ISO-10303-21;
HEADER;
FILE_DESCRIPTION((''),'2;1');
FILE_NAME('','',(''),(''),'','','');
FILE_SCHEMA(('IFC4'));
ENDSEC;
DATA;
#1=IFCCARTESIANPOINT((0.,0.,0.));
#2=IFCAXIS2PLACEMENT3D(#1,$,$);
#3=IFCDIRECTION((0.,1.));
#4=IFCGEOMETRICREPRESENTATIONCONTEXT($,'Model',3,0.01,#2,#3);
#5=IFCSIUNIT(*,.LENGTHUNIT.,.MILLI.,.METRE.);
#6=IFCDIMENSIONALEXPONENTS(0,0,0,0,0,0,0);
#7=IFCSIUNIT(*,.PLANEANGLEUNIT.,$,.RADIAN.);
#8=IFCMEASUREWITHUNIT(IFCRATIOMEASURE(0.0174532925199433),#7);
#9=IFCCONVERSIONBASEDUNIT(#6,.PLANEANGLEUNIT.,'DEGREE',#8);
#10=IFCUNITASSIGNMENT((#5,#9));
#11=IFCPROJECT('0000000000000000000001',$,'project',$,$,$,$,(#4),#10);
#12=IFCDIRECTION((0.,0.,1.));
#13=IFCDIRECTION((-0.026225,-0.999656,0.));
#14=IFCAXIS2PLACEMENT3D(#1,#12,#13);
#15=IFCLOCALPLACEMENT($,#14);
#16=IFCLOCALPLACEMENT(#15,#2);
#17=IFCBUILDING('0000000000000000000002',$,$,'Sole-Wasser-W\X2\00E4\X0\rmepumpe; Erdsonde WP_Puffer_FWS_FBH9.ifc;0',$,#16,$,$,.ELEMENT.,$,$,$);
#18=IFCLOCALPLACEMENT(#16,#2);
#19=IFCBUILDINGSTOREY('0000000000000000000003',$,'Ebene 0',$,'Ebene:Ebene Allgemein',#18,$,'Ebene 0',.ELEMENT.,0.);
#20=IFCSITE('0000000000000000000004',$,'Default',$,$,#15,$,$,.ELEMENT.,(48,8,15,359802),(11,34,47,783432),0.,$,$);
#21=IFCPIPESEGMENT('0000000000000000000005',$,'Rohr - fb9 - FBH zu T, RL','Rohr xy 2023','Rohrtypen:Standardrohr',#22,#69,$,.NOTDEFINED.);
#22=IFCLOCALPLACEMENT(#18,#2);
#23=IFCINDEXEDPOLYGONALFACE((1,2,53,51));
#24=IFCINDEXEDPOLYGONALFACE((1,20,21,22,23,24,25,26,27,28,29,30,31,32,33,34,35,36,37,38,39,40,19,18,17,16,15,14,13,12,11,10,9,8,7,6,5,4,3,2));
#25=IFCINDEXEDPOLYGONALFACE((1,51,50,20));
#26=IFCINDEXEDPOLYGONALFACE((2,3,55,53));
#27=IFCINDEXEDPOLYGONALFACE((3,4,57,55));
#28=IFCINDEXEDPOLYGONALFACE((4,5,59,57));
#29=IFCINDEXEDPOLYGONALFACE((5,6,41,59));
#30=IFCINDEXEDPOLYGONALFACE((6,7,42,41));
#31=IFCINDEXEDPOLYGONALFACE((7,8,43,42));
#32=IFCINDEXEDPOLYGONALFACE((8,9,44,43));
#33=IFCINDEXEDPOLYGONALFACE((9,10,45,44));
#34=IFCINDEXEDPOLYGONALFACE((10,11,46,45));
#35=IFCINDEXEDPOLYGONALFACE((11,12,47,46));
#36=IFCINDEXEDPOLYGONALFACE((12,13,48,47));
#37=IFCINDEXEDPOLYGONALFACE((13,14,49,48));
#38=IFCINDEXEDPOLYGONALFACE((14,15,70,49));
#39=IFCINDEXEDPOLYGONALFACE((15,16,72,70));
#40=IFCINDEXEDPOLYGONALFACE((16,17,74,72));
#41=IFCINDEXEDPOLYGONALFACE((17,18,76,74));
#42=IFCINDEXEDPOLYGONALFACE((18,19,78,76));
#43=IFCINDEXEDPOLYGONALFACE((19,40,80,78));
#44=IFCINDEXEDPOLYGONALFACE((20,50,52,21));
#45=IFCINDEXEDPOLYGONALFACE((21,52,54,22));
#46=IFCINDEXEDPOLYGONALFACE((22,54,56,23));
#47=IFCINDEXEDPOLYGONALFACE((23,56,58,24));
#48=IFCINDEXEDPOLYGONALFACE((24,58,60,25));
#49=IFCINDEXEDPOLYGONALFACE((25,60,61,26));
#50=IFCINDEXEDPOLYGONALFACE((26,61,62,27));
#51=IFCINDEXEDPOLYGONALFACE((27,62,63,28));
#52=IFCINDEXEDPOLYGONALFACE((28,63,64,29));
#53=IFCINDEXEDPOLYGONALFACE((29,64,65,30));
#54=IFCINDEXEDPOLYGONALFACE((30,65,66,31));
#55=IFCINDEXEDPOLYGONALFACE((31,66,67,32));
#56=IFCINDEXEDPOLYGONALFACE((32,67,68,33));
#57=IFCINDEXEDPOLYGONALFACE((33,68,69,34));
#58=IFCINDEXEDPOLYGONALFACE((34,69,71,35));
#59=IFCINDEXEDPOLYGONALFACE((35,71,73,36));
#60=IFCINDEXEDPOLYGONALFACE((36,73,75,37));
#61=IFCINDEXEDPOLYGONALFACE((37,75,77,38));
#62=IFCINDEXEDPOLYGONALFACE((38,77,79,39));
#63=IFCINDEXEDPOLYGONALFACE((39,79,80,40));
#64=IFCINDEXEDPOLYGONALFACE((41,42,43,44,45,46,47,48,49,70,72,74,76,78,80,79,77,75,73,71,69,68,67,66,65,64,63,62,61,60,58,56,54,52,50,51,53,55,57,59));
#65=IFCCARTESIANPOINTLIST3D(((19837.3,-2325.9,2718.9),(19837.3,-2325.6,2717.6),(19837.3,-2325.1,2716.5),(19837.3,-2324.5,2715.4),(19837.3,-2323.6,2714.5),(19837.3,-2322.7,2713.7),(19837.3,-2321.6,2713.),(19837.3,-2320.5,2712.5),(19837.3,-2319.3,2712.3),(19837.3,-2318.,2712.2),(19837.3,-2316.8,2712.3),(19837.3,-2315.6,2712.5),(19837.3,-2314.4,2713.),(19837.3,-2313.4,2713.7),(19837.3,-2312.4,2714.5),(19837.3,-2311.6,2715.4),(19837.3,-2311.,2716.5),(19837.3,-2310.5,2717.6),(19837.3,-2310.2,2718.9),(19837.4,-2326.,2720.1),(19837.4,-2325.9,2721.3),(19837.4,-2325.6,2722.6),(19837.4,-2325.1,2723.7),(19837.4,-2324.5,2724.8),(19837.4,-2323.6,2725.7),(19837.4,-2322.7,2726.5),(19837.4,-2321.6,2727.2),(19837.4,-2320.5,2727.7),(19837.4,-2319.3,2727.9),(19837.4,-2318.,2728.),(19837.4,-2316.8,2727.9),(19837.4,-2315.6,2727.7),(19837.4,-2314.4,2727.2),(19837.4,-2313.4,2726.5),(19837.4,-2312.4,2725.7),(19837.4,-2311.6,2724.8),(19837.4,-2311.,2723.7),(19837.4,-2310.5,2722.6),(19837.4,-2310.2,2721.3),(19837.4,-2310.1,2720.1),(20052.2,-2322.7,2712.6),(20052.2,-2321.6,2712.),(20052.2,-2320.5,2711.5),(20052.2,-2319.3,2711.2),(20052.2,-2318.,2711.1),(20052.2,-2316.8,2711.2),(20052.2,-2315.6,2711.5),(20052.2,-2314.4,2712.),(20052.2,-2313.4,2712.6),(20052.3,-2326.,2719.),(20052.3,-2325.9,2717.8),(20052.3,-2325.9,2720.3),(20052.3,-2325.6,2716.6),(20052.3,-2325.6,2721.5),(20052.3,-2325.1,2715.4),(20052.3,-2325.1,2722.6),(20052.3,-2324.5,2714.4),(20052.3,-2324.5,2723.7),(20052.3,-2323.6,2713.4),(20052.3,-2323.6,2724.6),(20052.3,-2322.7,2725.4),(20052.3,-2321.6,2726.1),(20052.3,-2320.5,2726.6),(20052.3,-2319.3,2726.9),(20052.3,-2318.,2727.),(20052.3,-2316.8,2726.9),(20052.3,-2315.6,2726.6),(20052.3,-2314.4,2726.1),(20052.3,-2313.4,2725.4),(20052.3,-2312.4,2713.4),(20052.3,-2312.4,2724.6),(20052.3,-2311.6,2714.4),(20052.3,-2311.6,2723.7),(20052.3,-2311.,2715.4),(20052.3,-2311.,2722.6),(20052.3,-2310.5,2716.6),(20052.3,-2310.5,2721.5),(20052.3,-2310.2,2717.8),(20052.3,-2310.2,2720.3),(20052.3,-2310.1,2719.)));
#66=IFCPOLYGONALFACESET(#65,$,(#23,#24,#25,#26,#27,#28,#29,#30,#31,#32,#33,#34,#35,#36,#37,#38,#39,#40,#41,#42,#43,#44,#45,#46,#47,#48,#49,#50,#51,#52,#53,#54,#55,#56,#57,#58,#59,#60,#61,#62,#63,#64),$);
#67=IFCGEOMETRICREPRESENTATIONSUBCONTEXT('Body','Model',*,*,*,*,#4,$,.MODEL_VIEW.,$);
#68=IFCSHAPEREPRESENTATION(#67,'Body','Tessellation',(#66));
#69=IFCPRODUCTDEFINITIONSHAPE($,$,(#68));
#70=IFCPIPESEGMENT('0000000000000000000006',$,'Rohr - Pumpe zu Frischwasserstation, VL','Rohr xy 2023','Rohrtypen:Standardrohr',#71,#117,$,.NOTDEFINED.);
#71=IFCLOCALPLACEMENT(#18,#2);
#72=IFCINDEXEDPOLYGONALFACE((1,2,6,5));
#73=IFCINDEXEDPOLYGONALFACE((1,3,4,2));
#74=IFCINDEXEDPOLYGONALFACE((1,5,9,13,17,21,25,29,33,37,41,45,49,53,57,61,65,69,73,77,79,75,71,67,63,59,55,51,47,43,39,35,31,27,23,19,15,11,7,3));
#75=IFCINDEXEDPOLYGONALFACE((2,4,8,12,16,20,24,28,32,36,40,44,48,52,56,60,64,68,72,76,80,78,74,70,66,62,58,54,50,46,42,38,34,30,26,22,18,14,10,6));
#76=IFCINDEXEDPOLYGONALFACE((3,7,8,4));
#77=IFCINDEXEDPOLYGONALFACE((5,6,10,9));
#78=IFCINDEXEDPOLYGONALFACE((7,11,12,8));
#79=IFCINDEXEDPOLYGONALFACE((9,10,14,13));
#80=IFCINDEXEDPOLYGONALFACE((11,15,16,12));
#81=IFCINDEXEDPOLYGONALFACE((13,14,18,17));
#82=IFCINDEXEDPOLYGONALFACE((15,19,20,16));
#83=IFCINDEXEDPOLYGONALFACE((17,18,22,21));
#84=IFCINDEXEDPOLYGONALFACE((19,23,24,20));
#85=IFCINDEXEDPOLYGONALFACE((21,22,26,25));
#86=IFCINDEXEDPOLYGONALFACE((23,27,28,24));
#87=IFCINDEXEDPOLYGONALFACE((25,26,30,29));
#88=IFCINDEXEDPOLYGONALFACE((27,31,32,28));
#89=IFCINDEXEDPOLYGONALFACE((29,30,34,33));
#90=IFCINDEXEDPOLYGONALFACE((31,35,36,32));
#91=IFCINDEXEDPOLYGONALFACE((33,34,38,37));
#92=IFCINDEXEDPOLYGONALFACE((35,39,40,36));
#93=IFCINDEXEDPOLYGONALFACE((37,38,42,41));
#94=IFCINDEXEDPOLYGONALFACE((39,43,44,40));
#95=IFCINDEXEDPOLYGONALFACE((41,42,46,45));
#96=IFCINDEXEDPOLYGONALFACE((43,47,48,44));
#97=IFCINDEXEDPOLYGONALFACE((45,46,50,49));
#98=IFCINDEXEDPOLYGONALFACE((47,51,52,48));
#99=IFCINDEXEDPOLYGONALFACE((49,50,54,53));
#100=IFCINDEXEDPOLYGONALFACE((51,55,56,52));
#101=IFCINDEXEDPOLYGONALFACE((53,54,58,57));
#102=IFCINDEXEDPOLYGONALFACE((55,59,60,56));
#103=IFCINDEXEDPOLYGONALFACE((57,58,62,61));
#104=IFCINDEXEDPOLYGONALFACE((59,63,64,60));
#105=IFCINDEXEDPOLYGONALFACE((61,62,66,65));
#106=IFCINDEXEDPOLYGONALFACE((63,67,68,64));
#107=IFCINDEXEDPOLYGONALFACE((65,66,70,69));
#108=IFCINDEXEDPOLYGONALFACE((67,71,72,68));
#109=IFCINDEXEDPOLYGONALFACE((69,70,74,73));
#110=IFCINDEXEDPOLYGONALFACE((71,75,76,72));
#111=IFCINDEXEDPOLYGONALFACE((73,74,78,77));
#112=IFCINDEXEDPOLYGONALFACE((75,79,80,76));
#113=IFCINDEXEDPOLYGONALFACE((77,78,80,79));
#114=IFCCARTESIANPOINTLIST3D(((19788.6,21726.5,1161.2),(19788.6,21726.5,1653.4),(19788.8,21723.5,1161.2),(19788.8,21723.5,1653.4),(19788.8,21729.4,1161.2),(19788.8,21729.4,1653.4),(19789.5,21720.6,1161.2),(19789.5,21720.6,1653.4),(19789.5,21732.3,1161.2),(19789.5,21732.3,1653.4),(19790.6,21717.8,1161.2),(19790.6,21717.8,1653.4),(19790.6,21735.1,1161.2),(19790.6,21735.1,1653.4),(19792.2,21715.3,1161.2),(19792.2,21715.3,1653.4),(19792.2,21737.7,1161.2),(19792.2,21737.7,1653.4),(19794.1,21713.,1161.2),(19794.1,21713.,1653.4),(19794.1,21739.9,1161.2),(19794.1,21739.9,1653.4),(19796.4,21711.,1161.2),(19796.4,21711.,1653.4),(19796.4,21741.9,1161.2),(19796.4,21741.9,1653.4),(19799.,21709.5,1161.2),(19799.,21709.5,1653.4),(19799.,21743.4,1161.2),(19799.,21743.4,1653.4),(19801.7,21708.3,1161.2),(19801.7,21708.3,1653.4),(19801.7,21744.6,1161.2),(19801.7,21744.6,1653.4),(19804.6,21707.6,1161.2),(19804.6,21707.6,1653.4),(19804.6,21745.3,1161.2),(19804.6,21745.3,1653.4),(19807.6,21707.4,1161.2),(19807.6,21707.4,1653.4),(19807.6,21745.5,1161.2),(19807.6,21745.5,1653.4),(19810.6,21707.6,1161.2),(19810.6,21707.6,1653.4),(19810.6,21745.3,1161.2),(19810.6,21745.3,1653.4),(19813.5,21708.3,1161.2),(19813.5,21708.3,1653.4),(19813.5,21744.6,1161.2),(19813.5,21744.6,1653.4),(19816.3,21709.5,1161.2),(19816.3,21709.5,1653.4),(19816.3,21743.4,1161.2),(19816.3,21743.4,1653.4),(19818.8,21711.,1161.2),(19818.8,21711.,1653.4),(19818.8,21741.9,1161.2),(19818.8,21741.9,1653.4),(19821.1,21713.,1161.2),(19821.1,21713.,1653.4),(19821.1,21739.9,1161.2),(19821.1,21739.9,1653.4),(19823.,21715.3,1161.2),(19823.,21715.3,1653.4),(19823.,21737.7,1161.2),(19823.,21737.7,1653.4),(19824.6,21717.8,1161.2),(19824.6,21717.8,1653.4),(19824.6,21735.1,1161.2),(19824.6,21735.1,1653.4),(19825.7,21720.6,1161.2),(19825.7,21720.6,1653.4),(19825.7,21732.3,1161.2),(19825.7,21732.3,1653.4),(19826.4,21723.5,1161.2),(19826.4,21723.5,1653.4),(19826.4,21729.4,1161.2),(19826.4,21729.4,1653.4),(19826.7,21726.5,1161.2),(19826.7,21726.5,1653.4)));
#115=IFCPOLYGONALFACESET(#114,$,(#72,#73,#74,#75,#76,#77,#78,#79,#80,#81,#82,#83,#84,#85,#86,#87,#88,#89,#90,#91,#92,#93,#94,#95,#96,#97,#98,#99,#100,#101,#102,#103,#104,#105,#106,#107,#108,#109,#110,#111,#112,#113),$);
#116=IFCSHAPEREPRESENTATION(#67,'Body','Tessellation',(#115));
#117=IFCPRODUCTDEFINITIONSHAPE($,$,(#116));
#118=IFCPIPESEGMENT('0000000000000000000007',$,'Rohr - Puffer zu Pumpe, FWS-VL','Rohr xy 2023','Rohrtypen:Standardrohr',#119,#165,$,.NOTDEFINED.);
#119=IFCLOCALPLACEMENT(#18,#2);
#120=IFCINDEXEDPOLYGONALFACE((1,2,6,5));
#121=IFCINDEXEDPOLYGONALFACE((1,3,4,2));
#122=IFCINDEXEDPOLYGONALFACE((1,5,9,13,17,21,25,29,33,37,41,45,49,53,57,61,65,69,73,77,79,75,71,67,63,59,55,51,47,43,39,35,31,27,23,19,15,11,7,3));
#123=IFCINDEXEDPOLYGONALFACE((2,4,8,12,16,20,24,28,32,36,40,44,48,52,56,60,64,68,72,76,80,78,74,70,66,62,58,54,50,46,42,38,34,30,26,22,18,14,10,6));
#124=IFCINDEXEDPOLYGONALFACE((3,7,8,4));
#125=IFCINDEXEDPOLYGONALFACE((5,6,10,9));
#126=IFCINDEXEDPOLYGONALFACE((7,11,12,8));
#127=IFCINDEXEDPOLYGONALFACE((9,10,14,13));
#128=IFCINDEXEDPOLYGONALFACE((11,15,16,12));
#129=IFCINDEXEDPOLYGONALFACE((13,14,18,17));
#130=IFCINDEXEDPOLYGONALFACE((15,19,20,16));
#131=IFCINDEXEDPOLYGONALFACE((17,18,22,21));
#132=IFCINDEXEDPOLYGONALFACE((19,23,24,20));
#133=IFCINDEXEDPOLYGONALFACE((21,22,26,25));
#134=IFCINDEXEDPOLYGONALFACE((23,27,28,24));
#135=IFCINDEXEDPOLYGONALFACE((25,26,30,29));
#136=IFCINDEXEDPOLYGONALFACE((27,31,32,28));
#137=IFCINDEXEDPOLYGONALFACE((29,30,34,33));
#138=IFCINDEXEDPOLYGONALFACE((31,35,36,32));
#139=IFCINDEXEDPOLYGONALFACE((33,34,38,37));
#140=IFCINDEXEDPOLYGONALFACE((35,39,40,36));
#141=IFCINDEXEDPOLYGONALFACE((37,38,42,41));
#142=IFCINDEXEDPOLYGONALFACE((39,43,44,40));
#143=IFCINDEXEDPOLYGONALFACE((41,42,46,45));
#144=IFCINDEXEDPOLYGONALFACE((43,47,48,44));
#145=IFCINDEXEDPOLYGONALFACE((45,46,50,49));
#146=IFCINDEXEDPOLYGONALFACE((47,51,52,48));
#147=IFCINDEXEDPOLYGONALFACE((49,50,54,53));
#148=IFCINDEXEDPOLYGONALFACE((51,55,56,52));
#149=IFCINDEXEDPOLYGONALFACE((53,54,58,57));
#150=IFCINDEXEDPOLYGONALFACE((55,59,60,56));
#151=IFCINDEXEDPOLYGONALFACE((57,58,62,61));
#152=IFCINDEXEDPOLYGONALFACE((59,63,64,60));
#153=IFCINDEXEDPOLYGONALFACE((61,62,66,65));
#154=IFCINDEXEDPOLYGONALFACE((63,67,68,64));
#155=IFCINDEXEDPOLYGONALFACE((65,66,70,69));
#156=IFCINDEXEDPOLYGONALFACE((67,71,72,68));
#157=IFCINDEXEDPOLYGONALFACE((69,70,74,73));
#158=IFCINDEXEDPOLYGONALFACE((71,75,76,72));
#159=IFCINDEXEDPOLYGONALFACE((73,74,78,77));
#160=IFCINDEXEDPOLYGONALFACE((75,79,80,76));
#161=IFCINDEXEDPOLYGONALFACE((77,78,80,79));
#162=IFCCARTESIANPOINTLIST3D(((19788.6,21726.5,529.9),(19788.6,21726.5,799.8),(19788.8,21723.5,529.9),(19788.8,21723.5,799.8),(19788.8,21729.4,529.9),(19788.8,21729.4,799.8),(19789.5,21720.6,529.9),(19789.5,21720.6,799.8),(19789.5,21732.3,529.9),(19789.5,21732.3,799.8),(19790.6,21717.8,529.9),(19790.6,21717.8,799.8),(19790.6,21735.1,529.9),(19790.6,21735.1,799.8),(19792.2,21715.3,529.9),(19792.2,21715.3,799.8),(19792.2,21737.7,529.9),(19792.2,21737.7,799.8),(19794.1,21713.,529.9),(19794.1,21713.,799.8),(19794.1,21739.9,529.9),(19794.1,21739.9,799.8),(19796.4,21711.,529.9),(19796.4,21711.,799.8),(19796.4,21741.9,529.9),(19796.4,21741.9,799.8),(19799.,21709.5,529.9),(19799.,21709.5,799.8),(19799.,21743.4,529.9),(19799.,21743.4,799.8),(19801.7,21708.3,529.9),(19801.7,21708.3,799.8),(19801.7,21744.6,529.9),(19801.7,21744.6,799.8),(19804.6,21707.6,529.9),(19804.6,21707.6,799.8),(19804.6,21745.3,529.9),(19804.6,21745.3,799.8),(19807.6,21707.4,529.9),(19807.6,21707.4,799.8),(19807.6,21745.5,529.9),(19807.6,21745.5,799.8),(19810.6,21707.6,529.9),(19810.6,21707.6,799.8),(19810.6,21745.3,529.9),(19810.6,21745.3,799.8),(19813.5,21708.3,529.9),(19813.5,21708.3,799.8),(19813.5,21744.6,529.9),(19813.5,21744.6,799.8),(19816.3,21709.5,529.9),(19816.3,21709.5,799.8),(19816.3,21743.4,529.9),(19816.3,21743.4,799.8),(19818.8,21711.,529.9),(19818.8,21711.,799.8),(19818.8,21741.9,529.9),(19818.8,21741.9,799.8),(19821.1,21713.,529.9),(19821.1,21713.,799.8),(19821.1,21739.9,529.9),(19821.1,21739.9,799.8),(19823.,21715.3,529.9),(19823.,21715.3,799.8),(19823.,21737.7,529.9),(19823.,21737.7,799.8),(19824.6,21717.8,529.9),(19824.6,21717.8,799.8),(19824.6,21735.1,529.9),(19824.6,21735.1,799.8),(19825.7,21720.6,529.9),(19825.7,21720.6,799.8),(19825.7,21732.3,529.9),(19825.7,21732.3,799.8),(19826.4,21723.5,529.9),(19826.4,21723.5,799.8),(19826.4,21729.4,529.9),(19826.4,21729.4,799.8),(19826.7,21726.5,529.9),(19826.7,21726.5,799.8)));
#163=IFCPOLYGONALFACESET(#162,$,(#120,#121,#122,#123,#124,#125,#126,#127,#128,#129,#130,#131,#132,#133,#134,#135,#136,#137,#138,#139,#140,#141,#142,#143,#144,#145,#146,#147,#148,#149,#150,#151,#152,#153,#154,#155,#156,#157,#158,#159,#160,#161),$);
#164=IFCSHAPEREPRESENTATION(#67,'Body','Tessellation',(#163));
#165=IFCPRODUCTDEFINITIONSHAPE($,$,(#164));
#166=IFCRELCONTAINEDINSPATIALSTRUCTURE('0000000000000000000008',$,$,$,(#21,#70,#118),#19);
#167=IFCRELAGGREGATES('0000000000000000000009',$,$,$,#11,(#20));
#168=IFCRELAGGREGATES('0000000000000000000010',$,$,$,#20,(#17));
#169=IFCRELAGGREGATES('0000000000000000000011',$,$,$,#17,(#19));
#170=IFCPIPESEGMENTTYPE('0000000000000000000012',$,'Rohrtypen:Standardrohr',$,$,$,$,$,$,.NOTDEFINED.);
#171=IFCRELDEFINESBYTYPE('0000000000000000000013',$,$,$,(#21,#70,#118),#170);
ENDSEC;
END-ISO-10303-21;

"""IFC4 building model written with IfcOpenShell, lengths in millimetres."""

from ifc_helpers import new_model, entity, si_unit, converted_unit, direction, frame, origin, place, context, subcontext, project, spatial, indexed_curve, outline, extrude, type_object, element, save


model = new_model("IFC4")

# Units and contexts
model_context = context("Model", 3, precision=0.01, world=origin(), true_north=direction((0.0, 1.0)))
body_context = subcontext(model_context, "Body", "Model", "MODEL_VIEW")
ifc_project = project(units=[si_unit("LENGTHUNIT", "METRE", prefix="MILLI"), converted_unit("PLANEANGLEUNIT", "DEGREE", entity("IfcRatioMeasure", 0.0174532925199433), si_unit("PLANEANGLEUNIT", "RADIAN"), dimensions=[0, 0, 0, 0, 0, 0, 0])], contexts=[model_context])

# Site, building, storey
site_placement = place(None, frame((0.0, 0.0, 0.0), z_axis=(0.0, 0.0, 1.0), x_axis=(-0.026225, -0.999656, 0.0)))
site = spatial("IfcSite", under=ifc_project, at=site_placement, Name="Default", CompositionType="ELEMENT", RefLatitude=(48, 8, 15, 359802), RefLongitude=(11, 34, 47, 783432), RefElevation=0.0)
building_placement = place(site_placement, origin())
building = spatial("IfcBuilding", under=site, at=building_placement, Description="Sole-Wasser-Wärmepumpe; Erdsonde WP_Puffer_FWS_FBH9.ifc;0", CompositionType="ELEMENT")
storey_placement = place(building_placement, origin())
storey = spatial("IfcBuildingStorey", under=building, at=storey_placement, Name="Ebene 0", ObjectType="Ebene:Ebene Allgemein", LongName="Ebene 0", CompositionType="ELEMENT", Elevation=0.0)

# Pipe segments
pipe_segment_type = type_object("IfcPipeSegmentType", Name="Rohrtypen:Standardrohr", PredefinedType="NOTDEFINED")
pipe_segment_1_placement = place(storey_placement, origin())
element("IfcPipeSegment", 1, at=pipe_segment_1_placement, inside=storey, type_object=pipe_segment_type, Name="Rohr - fb9 - FBH zu T, RL", Description="Rohr xy 2023", ObjectType="Rohrtypen:Standardrohr", PredefinedType="NOTDEFINED", context=body_context, shape_type="SweptSolid", body=[
    extrude(outline(indexed_curve([(7.9, 0.0), (7.8, 1.2), (7.6, 2.5), (7.1, 3.6), (6.4, 4.7), (5.6, 5.6), (4.7, 6.4), (3.6, 7.1), (2.5, 7.6), (1.2, 7.8), (0.0, 7.9), (-1.2, 7.8), (-2.5, 7.6), (-3.6, 7.1), (-4.7, 6.4), (-5.6, 5.6), (-6.4, 4.7), (-7.1, 3.6), (-7.6, 2.5), (-7.8, 1.2), (-7.9, 0.0), (-7.8, -1.2), (-7.6, -2.5), (-7.1, -3.6), (-6.4, -4.7), (-5.6, -5.6), (-4.7, -6.4), (-3.6, -7.1), (-2.5, -7.6), (-1.2, -7.8), (0.0, -7.9), (1.2, -7.8), (2.5, -7.6), (3.6, -7.1), (4.7, -6.4), (5.6, -5.6), (6.4, -4.7), (7.1, -3.6), (7.6, -2.5), (7.8, -1.2), (7.9, 0.0)], self_intersect=False)), frame((20052.3, -2318.0, 2719.0), z_axis=(-0.999988, 0.0, 0.005), x_axis=(0.0, 1.0, 0.0)), (0.0, 0.0, 1.0), 214.9),
])
pipe_segment_2_placement = place(storey_placement, origin())
element("IfcPipeSegment", 2, at=pipe_segment_2_placement, inside=storey, type_object=pipe_segment_type, Name="Rohr - Pumpe zu Frischwasserstation, VL", Description="Rohr xy 2023", ObjectType="Rohrtypen:Standardrohr", PredefinedType="NOTDEFINED", context=body_context, shape_type="SweptSolid", body=[
    extrude(outline(indexed_curve([(19.1, 0.0), (18.8, 3.0), (18.1, 5.9), (17.0, 8.6), (15.4, 11.2), (13.5, 13.5), (11.2, 15.4), (8.6, 17.0), (5.9, 18.1), (3.0, 18.8), (0.0, 19.0), (-3.0, 18.8), (-5.9, 18.1), (-8.6, 17.0), (-11.2, 15.4), (-13.5, 13.5), (-15.4, 11.2), (-17.0, 8.6), (-18.1, 5.9), (-18.8, 3.0), (-19.1, 0.0), (-18.8, -3.0), (-18.1, -5.9), (-17.0, -8.6), (-15.4, -11.2), (-13.5, -13.5), (-11.2, -15.4), (-8.6, -17.0), (-5.9, -18.1), (-3.0, -18.8), (0.0, -19.0), (3.0, -18.8), (5.9, -18.1), (8.6, -17.0), (11.2, -15.4), (13.5, -13.5), (15.4, -11.2), (17.0, -8.6), (18.1, -5.9), (18.8, -3.0), (19.1, 0.0)], self_intersect=False)), frame((19807.6, 21726.5, 1161.2), z_axis=(0.000002, 0.000002, 1.0), x_axis=(-1.0, 0.0, 0.000002)), (0.0, 0.0, 1.0), 492.1),
])
pipe_segment_3_placement = place(storey_placement, origin())
element("IfcPipeSegment", 3, at=pipe_segment_3_placement, inside=storey, type_object=pipe_segment_type, Name="Rohr - Puffer zu Pumpe, FWS-VL", Description="Rohr xy 2023", ObjectType="Rohrtypen:Standardrohr", PredefinedType="NOTDEFINED", context=body_context, shape_type="SweptSolid", body=[
    extrude(outline(indexed_curve([(19.1, 0.0), (18.8, 3.0), (18.1, 5.9), (17.0, 8.6), (15.4, 11.2), (13.5, 13.5), (11.2, 15.4), (8.6, 17.0), (5.9, 18.1), (3.0, 18.8), (0.0, 19.0), (-3.0, 18.8), (-5.9, 18.1), (-8.6, 17.0), (-11.2, 15.4), (-13.5, 13.5), (-15.4, 11.2), (-17.0, 8.6), (-18.1, 5.9), (-18.8, 3.0), (-19.1, 0.0), (-18.8, -3.0), (-18.1, -5.9), (-17.0, -8.6), (-15.4, -11.2), (-13.5, -13.5), (-11.2, -15.4), (-8.6, -17.0), (-5.9, -18.1), (-3.0, -18.8), (0.0, -19.0), (3.0, -18.8), (5.9, -18.1), (8.6, -17.0), (11.2, -15.4), (13.5, -13.5), (15.4, -11.2), (17.0, -8.6), (18.1, -5.9), (18.8, -3.0), (19.1, 0.0)], self_intersect=False)), frame((19807.6, 21726.5, 529.9), z_axis=(0.000002, 0.000002, 1.0), x_axis=(-1.0, 0.0, 0.000002)), (0.0, 0.0, 1.0), 269.9),
])

save(model, "model.ifc")
